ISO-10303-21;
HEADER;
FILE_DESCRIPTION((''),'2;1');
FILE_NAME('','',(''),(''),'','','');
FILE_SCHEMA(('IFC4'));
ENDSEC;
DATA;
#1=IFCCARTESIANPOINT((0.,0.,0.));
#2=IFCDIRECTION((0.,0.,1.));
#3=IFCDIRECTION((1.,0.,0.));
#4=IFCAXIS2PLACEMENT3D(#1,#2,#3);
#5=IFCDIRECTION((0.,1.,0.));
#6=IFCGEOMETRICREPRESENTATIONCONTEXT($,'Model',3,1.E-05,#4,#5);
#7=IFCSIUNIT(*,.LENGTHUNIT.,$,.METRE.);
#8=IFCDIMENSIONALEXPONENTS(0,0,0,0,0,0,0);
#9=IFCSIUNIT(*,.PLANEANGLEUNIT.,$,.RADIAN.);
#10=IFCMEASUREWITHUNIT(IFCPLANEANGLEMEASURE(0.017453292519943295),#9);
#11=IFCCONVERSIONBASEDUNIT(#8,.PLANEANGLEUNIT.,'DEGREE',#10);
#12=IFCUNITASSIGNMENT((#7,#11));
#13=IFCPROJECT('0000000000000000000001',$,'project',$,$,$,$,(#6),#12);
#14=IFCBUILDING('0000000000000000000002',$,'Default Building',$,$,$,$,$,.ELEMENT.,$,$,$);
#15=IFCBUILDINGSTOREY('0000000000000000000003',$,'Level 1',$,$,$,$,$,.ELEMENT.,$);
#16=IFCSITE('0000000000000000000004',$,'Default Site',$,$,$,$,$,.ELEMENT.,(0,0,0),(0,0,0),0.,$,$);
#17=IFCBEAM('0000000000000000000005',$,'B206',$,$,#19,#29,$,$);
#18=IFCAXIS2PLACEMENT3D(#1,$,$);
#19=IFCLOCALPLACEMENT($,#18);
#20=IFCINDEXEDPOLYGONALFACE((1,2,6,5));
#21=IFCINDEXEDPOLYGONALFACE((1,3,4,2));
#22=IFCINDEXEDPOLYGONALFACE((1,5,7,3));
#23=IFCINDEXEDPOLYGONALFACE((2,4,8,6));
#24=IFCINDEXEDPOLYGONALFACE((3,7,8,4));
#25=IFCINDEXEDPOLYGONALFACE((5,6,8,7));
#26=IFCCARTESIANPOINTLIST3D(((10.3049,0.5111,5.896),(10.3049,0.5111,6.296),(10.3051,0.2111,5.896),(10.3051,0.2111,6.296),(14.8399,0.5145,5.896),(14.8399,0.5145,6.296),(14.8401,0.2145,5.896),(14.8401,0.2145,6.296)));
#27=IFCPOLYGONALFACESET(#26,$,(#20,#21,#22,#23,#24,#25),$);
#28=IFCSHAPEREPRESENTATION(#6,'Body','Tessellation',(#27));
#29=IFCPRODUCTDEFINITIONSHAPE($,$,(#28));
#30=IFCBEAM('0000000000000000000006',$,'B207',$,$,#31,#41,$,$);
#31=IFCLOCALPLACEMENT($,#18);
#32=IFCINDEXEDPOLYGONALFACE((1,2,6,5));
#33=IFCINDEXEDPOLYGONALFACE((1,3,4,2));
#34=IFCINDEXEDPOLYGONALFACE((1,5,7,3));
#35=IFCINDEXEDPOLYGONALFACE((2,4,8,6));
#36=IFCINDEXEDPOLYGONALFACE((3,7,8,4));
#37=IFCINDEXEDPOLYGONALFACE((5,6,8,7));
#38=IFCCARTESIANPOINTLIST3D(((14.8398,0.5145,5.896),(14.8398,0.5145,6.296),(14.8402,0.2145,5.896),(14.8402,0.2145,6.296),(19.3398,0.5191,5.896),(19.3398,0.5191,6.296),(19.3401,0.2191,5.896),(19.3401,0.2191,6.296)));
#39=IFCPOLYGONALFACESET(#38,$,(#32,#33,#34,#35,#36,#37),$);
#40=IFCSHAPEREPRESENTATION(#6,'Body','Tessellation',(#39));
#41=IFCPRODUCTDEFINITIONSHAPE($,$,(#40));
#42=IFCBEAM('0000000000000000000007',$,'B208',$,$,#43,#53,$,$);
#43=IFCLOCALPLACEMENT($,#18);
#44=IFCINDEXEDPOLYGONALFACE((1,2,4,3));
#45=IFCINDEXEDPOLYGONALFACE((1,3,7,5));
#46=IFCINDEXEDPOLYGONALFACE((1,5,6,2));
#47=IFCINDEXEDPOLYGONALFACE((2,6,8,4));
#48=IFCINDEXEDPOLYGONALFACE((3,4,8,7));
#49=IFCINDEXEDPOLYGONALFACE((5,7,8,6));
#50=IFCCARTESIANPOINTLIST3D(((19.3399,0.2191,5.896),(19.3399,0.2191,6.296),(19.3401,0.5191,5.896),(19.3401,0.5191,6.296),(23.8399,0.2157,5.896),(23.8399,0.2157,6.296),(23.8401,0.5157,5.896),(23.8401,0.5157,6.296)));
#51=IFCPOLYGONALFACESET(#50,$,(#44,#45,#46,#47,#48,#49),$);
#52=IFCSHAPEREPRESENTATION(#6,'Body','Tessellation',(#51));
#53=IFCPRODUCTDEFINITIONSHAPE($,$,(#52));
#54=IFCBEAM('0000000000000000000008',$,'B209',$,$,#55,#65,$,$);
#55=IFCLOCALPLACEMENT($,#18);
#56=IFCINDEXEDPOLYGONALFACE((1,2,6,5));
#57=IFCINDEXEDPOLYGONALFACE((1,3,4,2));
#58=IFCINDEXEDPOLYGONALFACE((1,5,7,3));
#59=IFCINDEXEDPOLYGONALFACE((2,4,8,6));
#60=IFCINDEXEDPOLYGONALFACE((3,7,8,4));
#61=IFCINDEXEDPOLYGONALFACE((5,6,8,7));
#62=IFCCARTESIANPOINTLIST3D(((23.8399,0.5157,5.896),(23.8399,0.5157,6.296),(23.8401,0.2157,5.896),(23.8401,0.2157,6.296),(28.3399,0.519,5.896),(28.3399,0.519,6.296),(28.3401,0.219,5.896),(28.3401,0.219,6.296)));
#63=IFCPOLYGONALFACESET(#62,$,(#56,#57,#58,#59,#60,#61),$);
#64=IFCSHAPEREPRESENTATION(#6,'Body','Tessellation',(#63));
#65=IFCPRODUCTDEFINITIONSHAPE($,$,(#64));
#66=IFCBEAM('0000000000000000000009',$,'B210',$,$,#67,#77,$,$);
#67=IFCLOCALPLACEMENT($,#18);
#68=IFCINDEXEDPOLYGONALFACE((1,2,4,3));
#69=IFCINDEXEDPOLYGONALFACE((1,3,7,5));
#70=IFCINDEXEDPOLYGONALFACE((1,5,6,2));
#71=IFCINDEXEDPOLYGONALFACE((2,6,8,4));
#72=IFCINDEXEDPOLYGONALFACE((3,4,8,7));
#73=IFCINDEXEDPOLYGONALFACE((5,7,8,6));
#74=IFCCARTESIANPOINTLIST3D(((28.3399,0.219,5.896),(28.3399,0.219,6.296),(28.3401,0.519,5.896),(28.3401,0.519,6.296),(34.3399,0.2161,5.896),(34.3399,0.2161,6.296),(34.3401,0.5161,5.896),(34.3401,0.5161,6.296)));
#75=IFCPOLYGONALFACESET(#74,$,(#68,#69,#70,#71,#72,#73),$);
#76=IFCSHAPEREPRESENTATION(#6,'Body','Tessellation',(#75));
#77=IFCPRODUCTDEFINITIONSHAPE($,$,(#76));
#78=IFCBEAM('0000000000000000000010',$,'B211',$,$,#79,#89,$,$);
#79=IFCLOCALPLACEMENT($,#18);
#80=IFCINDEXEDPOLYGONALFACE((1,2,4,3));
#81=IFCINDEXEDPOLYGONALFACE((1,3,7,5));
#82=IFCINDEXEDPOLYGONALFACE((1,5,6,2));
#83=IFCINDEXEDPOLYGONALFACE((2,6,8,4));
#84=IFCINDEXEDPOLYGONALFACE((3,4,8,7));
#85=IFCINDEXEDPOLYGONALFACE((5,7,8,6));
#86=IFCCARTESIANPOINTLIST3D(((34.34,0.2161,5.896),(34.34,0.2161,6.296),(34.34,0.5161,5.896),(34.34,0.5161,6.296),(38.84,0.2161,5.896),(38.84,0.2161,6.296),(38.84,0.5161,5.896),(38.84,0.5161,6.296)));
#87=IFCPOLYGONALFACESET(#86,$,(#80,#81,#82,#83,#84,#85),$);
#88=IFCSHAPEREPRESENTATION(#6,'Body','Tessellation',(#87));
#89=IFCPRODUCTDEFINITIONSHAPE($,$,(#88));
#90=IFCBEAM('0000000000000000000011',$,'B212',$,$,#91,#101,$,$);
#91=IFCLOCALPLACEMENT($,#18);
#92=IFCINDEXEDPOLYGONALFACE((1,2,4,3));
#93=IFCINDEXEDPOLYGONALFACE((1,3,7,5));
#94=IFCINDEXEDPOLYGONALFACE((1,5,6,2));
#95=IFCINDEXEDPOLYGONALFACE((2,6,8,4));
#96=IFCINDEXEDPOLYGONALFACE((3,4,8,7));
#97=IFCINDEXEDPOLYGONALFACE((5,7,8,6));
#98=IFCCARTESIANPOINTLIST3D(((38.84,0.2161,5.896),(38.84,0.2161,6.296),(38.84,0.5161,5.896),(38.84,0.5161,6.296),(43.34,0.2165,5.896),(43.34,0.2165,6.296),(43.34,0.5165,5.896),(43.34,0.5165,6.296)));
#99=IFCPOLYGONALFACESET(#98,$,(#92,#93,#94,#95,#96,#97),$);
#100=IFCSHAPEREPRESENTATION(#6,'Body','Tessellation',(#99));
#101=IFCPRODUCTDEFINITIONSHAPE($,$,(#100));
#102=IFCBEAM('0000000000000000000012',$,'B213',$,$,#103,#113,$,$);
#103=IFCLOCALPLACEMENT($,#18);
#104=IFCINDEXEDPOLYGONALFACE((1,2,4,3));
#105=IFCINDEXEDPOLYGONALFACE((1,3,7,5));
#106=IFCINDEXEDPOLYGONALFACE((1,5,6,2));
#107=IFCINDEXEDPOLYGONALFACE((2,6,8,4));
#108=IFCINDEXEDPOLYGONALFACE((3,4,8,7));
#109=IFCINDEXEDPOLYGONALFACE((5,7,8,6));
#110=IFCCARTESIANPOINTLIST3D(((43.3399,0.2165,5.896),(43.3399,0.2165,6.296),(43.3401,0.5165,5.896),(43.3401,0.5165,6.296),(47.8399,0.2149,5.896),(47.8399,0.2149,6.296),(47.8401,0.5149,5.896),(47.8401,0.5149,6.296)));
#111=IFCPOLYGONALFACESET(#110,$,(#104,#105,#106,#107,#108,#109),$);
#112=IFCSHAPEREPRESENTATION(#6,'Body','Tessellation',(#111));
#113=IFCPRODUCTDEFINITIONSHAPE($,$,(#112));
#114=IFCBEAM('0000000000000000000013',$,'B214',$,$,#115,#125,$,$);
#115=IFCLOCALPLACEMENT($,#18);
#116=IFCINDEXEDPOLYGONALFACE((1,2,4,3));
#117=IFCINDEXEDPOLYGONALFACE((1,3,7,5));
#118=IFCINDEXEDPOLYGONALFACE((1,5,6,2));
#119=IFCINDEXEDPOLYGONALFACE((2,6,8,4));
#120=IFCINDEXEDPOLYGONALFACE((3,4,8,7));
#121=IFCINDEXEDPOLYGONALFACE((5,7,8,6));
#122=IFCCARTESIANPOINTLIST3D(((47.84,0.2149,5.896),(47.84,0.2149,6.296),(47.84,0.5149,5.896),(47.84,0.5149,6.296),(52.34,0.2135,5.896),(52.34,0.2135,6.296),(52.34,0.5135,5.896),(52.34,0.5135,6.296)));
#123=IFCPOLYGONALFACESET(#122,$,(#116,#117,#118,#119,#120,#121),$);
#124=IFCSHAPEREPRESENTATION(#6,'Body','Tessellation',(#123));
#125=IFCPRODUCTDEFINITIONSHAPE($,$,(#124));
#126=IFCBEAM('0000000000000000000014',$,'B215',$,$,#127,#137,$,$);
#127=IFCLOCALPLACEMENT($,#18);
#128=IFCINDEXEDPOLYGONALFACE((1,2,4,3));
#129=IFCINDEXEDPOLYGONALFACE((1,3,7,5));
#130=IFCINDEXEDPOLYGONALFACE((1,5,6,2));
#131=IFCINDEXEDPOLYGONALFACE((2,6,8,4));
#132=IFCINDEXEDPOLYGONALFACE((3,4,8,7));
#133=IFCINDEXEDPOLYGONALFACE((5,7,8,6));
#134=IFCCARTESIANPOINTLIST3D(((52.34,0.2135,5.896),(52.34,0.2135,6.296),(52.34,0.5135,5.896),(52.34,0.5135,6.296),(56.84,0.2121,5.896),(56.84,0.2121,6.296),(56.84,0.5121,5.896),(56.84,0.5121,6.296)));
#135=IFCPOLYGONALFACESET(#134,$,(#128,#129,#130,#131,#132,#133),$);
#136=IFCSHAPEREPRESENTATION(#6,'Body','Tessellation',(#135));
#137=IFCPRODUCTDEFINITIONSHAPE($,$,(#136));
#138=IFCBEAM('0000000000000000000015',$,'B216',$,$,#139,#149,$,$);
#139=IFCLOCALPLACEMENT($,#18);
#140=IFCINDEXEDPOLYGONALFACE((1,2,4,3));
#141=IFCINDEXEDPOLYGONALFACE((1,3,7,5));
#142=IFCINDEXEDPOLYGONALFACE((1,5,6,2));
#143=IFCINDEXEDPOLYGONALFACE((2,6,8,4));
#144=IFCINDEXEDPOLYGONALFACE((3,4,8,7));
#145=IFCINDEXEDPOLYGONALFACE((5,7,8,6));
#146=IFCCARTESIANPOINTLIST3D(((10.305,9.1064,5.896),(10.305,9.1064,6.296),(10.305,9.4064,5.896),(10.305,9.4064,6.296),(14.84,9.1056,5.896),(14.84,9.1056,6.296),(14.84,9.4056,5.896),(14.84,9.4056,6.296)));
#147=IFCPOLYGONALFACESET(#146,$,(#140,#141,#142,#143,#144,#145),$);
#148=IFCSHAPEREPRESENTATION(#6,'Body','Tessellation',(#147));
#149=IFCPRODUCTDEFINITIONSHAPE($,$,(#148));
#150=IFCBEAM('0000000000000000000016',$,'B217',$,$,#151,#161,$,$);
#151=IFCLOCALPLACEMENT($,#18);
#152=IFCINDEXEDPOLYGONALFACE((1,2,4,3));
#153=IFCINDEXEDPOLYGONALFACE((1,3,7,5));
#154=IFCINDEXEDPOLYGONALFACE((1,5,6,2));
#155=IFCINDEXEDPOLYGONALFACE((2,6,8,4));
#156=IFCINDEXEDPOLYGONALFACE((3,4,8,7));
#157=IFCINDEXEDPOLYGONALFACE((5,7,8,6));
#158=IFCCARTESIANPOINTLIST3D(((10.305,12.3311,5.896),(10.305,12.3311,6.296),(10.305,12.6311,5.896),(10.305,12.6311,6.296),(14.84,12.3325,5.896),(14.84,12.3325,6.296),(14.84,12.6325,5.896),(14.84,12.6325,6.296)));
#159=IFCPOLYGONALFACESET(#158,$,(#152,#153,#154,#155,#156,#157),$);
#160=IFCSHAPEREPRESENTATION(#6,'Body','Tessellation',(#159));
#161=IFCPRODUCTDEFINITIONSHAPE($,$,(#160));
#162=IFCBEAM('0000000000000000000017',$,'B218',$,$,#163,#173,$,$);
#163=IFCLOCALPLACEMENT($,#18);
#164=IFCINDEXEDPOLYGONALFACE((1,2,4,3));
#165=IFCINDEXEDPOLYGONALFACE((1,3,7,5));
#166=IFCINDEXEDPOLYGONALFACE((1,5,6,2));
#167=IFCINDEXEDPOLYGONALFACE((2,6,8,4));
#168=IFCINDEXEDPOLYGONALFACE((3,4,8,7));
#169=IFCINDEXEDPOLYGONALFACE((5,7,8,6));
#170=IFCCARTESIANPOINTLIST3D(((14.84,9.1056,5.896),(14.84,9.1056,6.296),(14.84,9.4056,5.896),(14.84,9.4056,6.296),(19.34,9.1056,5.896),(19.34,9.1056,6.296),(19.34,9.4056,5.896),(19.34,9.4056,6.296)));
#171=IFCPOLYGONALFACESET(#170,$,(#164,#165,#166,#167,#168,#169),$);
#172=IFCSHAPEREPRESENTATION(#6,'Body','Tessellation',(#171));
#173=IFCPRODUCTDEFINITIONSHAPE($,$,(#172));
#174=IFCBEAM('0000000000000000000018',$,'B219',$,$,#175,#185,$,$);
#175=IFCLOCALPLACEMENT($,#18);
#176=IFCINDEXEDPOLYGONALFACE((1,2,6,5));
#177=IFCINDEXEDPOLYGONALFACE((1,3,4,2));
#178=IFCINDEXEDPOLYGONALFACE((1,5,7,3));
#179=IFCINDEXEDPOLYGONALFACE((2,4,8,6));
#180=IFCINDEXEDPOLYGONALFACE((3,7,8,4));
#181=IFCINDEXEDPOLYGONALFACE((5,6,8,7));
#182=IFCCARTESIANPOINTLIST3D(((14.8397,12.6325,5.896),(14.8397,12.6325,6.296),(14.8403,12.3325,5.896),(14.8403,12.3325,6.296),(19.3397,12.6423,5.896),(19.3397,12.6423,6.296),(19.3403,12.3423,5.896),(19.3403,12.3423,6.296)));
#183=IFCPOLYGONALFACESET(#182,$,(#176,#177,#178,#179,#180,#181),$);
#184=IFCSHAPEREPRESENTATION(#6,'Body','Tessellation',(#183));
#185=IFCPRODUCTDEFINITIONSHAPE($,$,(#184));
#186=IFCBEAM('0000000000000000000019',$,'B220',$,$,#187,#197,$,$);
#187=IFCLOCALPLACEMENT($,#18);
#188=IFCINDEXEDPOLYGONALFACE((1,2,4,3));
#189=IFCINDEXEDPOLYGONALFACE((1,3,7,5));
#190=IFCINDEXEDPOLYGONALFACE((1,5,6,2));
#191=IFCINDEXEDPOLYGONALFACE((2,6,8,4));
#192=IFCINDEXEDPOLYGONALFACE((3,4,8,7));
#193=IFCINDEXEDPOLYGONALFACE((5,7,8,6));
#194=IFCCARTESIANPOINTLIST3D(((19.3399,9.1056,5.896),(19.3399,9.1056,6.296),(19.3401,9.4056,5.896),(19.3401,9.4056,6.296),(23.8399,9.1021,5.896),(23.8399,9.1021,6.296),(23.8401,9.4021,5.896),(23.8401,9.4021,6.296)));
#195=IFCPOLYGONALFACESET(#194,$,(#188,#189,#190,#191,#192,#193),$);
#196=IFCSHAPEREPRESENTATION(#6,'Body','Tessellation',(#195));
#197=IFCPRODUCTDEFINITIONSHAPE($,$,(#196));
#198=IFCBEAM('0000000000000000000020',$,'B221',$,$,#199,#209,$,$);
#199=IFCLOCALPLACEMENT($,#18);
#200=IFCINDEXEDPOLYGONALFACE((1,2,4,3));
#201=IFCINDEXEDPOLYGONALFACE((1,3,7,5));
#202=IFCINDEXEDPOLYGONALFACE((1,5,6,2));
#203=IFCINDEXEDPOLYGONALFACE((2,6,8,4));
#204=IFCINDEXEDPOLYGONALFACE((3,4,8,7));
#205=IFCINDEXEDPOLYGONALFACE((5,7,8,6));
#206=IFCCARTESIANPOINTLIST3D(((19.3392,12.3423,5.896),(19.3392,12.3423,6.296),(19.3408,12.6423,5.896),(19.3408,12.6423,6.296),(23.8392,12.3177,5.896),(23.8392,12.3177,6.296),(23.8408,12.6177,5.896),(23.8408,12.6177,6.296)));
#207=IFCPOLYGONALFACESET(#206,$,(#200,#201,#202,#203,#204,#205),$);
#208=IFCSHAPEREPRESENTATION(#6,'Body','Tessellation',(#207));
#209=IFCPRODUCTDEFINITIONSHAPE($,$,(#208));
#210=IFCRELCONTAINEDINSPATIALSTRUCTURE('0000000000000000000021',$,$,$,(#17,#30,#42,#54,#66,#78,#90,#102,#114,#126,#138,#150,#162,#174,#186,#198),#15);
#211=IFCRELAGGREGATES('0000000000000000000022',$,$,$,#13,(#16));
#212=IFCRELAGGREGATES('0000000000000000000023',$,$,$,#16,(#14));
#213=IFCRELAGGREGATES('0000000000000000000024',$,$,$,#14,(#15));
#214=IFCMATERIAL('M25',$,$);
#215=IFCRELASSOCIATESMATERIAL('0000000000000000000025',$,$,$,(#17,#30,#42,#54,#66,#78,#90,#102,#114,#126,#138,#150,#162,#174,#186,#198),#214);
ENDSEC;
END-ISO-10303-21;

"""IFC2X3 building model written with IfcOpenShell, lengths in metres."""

from ifc_helpers import new_model, entity, si_unit, converted_unit, direction, frame, frame_2d, origin_with_axes, place, context, project, spatial, rectangle, extrude, material, element, save


model = new_model("IFC2X3")

# Units and contexts
model_context = context("Model", 3, precision=1e-05, world=origin_with_axes(), true_north=direction((0.0, 1.0, 0.0)))
ifc_project = project(units=[si_unit("LENGTHUNIT", "METRE"), converted_unit("PLANEANGLEUNIT", "DEGREE", entity("IfcPlaneAngleMeasure", 0.017453292519943295), si_unit("PLANEANGLEUNIT", "RADIAN"), dimensions=[0, 0, 0, 0, 0, 0, 0])], contexts=[model_context])

# Site, building, storey
site = spatial("IfcSite", under=ifc_project, Name="Default Site", CompositionType="ELEMENT", RefLatitude=(0, 0, 0), RefLongitude=(0, 0, 0), RefElevation=0.0)
building = spatial("IfcBuilding", under=site, Name="Default Building", CompositionType="ELEMENT")
storey = spatial("IfcBuildingStorey", under=building, Name="Level 1", CompositionType="ELEMENT")

# Beams
ifc_material = material(Name="M25")
placement = place(None, origin_with_axes())
element("IfcBeam", 1, at=placement, inside=storey, material=ifc_material, Name="B206", context=model_context, shape_type="SweptSolid", body=[
    extrude(rectangle(XDim=0.3, YDim=0.4, at=frame_2d((0.0, 0.0), x_axis=(0.0, 1.0, 0.0))), frame((10.305, 0.3611, 6.096), z_axis=(1.0, 0.000762, 0.0), x_axis=(0.0, 0.0, -1.0)), (0.0, 0.0, 1.0), 4.535),
])
element("IfcBeam", 2, at=placement, inside=storey, material=ifc_material, Name="B207", context=model_context, shape_type="SweptSolid", body=[
    extrude(rectangle(XDim=0.3, YDim=0.4, at=frame_2d((0.0, 0.0), x_axis=(0.0, 1.0, 0.0))), frame((14.84, 0.3645, 6.096), z_axis=(0.999999, 0.00101, 0.0), x_axis=(0.0, 0.0, -1.0)), (0.0, 0.0, 1.0), 4.5),
])
element("IfcBeam", 3, at=placement, inside=storey, material=ifc_material, Name="B208", context=model_context, shape_type="SweptSolid", body=[
    extrude(rectangle(XDim=0.3, YDim=0.4, at=frame_2d((0.0, 0.0), x_axis=(0.0, 1.0, 0.0))), frame((19.34, 0.3691, 6.096), z_axis=(1.0, -0.000757, 0.0), x_axis=(0.0, 0.0, -1.0)), (0.0, 0.0, 1.0), 4.5),
])
element("IfcBeam", 4, at=placement, inside=storey, material=ifc_material, Name="B209", context=model_context, shape_type="SweptSolid", body=[
    extrude(rectangle(XDim=0.3, YDim=0.4, at=frame_2d((0.0, 0.0), x_axis=(0.0, 1.0, 0.0))), frame((23.84, 0.3657, 6.096), z_axis=(1.0, 0.00075, 0.0), x_axis=(0.0, 0.0, -1.0)), (0.0, 0.0, 1.0), 4.5),
])
element("IfcBeam", 5, at=placement, inside=storey, material=ifc_material, Name="B210", context=model_context, shape_type="SweptSolid", body=[
    extrude(rectangle(XDim=0.3, YDim=0.4, at=frame_2d((0.0, 0.0), x_axis=(0.0, 1.0, 0.0))), frame((28.34, 0.369, 6.096), z_axis=(1.0, -0.000487, 0.0), x_axis=(0.0, 0.0, -1.0)), (0.0, 0.0, 1.0), 6.0),
])
element("IfcBeam", 6, at=placement, inside=storey, material=ifc_material, Name="B211", context=model_context, shape_type="SweptSolid", body=[
    extrude(rectangle(XDim=0.3, YDim=0.4, at=frame_2d((0.0, 0.0), x_axis=(0.0, 1.0, 0.0))), frame((34.34, 0.3661, 6.096), z_axis=(1.0, 0.000003, 0.0), x_axis=(0.0, 0.0, -1.0)), (0.0, 0.0, 1.0), 4.5),
])
element("IfcBeam", 7, at=placement, inside=storey, material=ifc_material, Name="B212", context=model_context, shape_type="SweptSolid", body=[
    extrude(rectangle(XDim=0.3, YDim=0.4, at=frame_2d((0.0, 0.0), x_axis=(0.0, 1.0, 0.0))), frame((38.84, 0.3661, 6.096), z_axis=(1.0, 0.000077, 0.0), x_axis=(0.0, 0.0, -1.0)), (0.0, 0.0, 1.0), 4.5),
])
element("IfcBeam", 8, at=placement, inside=storey, material=ifc_material, Name="B213", context=model_context, shape_type="SweptSolid", body=[
    extrude(rectangle(XDim=0.3, YDim=0.4, at=frame_2d((0.0, 0.0), x_axis=(0.0, 1.0, 0.0))), frame((43.34, 0.3665, 6.096), z_axis=(1.0, -0.000358, 0.0), x_axis=(0.0, 0.0, -1.0)), (0.0, 0.0, 1.0), 4.5),
])
element("IfcBeam", 9, at=placement, inside=storey, material=ifc_material, Name="B214", context=model_context, shape_type="SweptSolid", body=[
    extrude(rectangle(XDim=0.3, YDim=0.4, at=frame_2d((0.0, 0.0), x_axis=(0.0, 1.0, 0.0))), frame((47.84, 0.3649, 6.096), z_axis=(1.0, -0.000297, 0.0), x_axis=(0.0, 0.0, -1.0)), (0.0, 0.0, 1.0), 4.5),
])
element("IfcBeam", 10, at=placement, inside=storey, material=ifc_material, Name="B215", context=model_context, shape_type="SweptSolid", body=[
    extrude(rectangle(XDim=0.3, YDim=0.4, at=frame_2d((0.0, 0.0), x_axis=(0.0, 1.0, 0.0))), frame((52.34, 0.3635, 6.096), z_axis=(1.0, -0.000311, 0.0), x_axis=(0.0, 0.0, -1.0)), (0.0, 0.0, 1.0), 4.5),
])
element("IfcBeam", 11, at=placement, inside=storey, material=ifc_material, Name="B216", context=model_context, shape_type="SweptSolid", body=[
    extrude(rectangle(XDim=0.3, YDim=0.4, at=frame_2d((0.0, 0.0), x_axis=(0.0, 1.0, 0.0))), frame((10.305, 9.2564, 6.096), z_axis=(1.0, -0.000182, 0.0), x_axis=(0.0, 0.0, -1.0)), (0.0, 0.0, 1.0), 4.535),
])
element("IfcBeam", 12, at=placement, inside=storey, material=ifc_material, Name="B217", context=model_context, shape_type="SweptSolid", body=[
    extrude(rectangle(XDim=0.3, YDim=0.4, at=frame_2d((0.0, 0.0), x_axis=(0.0, 1.0, 0.0))), frame((10.305, 12.4811, 6.096), z_axis=(1.0, 0.000301, 0.0), x_axis=(0.0, 0.0, -1.0)), (0.0, 0.0, 1.0), 4.535),
])
element("IfcBeam", 13, at=placement, inside=storey, material=ifc_material, Name="B218", context=model_context, shape_type="SweptSolid", body=[
    extrude(rectangle(XDim=0.3, YDim=0.4, at=frame_2d((0.0, 0.0), x_axis=(0.0, 1.0, 0.0))), frame((14.84, 9.2556, 6.096), z_axis=(1.0, 0.000013, 0.0), x_axis=(0.0, 0.0, -1.0)), (0.0, 0.0, 1.0), 4.5),
])
element("IfcBeam", 14, at=placement, inside=storey, material=ifc_material, Name="B219", context=model_context, shape_type="SweptSolid", body=[
    extrude(rectangle(XDim=0.3, YDim=0.4, at=frame_2d((0.0, 0.0), x_axis=(0.0, 1.0, 0.0))), frame((14.84, 12.4825, 6.096), z_axis=(0.999998, 0.002176, 0.0), x_axis=(0.0, 0.0, -1.0)), (0.0, 0.0, 1.0), 4.5),
])
element("IfcBeam", 15, at=placement, inside=storey, material=ifc_material, Name="B220", context=model_context, shape_type="SweptSolid", body=[
    extrude(rectangle(XDim=0.3, YDim=0.4, at=frame_2d((0.0, 0.0), x_axis=(0.0, 1.0, 0.0))), frame((19.34, 9.2556, 6.096), z_axis=(1.0, -0.000779, 0.0), x_axis=(0.0, 0.0, -1.0)), (0.0, 0.0, 1.0), 4.5),
])
element("IfcBeam", 16, at=placement, inside=storey, material=ifc_material, Name="B221", context=model_context, shape_type="SweptSolid", body=[
    extrude(rectangle(XDim=0.3, YDim=0.4, at=frame_2d((0.0, 0.0), x_axis=(0.0, 1.0, 0.0))), frame((19.34, 12.4923, 6.096), z_axis=(0.999985, -0.005463, 0.0), x_axis=(0.0, 0.0, -1.0)), (0.0, 0.0, 1.0), 4.5001),
])

save(model, "model.ifc")
